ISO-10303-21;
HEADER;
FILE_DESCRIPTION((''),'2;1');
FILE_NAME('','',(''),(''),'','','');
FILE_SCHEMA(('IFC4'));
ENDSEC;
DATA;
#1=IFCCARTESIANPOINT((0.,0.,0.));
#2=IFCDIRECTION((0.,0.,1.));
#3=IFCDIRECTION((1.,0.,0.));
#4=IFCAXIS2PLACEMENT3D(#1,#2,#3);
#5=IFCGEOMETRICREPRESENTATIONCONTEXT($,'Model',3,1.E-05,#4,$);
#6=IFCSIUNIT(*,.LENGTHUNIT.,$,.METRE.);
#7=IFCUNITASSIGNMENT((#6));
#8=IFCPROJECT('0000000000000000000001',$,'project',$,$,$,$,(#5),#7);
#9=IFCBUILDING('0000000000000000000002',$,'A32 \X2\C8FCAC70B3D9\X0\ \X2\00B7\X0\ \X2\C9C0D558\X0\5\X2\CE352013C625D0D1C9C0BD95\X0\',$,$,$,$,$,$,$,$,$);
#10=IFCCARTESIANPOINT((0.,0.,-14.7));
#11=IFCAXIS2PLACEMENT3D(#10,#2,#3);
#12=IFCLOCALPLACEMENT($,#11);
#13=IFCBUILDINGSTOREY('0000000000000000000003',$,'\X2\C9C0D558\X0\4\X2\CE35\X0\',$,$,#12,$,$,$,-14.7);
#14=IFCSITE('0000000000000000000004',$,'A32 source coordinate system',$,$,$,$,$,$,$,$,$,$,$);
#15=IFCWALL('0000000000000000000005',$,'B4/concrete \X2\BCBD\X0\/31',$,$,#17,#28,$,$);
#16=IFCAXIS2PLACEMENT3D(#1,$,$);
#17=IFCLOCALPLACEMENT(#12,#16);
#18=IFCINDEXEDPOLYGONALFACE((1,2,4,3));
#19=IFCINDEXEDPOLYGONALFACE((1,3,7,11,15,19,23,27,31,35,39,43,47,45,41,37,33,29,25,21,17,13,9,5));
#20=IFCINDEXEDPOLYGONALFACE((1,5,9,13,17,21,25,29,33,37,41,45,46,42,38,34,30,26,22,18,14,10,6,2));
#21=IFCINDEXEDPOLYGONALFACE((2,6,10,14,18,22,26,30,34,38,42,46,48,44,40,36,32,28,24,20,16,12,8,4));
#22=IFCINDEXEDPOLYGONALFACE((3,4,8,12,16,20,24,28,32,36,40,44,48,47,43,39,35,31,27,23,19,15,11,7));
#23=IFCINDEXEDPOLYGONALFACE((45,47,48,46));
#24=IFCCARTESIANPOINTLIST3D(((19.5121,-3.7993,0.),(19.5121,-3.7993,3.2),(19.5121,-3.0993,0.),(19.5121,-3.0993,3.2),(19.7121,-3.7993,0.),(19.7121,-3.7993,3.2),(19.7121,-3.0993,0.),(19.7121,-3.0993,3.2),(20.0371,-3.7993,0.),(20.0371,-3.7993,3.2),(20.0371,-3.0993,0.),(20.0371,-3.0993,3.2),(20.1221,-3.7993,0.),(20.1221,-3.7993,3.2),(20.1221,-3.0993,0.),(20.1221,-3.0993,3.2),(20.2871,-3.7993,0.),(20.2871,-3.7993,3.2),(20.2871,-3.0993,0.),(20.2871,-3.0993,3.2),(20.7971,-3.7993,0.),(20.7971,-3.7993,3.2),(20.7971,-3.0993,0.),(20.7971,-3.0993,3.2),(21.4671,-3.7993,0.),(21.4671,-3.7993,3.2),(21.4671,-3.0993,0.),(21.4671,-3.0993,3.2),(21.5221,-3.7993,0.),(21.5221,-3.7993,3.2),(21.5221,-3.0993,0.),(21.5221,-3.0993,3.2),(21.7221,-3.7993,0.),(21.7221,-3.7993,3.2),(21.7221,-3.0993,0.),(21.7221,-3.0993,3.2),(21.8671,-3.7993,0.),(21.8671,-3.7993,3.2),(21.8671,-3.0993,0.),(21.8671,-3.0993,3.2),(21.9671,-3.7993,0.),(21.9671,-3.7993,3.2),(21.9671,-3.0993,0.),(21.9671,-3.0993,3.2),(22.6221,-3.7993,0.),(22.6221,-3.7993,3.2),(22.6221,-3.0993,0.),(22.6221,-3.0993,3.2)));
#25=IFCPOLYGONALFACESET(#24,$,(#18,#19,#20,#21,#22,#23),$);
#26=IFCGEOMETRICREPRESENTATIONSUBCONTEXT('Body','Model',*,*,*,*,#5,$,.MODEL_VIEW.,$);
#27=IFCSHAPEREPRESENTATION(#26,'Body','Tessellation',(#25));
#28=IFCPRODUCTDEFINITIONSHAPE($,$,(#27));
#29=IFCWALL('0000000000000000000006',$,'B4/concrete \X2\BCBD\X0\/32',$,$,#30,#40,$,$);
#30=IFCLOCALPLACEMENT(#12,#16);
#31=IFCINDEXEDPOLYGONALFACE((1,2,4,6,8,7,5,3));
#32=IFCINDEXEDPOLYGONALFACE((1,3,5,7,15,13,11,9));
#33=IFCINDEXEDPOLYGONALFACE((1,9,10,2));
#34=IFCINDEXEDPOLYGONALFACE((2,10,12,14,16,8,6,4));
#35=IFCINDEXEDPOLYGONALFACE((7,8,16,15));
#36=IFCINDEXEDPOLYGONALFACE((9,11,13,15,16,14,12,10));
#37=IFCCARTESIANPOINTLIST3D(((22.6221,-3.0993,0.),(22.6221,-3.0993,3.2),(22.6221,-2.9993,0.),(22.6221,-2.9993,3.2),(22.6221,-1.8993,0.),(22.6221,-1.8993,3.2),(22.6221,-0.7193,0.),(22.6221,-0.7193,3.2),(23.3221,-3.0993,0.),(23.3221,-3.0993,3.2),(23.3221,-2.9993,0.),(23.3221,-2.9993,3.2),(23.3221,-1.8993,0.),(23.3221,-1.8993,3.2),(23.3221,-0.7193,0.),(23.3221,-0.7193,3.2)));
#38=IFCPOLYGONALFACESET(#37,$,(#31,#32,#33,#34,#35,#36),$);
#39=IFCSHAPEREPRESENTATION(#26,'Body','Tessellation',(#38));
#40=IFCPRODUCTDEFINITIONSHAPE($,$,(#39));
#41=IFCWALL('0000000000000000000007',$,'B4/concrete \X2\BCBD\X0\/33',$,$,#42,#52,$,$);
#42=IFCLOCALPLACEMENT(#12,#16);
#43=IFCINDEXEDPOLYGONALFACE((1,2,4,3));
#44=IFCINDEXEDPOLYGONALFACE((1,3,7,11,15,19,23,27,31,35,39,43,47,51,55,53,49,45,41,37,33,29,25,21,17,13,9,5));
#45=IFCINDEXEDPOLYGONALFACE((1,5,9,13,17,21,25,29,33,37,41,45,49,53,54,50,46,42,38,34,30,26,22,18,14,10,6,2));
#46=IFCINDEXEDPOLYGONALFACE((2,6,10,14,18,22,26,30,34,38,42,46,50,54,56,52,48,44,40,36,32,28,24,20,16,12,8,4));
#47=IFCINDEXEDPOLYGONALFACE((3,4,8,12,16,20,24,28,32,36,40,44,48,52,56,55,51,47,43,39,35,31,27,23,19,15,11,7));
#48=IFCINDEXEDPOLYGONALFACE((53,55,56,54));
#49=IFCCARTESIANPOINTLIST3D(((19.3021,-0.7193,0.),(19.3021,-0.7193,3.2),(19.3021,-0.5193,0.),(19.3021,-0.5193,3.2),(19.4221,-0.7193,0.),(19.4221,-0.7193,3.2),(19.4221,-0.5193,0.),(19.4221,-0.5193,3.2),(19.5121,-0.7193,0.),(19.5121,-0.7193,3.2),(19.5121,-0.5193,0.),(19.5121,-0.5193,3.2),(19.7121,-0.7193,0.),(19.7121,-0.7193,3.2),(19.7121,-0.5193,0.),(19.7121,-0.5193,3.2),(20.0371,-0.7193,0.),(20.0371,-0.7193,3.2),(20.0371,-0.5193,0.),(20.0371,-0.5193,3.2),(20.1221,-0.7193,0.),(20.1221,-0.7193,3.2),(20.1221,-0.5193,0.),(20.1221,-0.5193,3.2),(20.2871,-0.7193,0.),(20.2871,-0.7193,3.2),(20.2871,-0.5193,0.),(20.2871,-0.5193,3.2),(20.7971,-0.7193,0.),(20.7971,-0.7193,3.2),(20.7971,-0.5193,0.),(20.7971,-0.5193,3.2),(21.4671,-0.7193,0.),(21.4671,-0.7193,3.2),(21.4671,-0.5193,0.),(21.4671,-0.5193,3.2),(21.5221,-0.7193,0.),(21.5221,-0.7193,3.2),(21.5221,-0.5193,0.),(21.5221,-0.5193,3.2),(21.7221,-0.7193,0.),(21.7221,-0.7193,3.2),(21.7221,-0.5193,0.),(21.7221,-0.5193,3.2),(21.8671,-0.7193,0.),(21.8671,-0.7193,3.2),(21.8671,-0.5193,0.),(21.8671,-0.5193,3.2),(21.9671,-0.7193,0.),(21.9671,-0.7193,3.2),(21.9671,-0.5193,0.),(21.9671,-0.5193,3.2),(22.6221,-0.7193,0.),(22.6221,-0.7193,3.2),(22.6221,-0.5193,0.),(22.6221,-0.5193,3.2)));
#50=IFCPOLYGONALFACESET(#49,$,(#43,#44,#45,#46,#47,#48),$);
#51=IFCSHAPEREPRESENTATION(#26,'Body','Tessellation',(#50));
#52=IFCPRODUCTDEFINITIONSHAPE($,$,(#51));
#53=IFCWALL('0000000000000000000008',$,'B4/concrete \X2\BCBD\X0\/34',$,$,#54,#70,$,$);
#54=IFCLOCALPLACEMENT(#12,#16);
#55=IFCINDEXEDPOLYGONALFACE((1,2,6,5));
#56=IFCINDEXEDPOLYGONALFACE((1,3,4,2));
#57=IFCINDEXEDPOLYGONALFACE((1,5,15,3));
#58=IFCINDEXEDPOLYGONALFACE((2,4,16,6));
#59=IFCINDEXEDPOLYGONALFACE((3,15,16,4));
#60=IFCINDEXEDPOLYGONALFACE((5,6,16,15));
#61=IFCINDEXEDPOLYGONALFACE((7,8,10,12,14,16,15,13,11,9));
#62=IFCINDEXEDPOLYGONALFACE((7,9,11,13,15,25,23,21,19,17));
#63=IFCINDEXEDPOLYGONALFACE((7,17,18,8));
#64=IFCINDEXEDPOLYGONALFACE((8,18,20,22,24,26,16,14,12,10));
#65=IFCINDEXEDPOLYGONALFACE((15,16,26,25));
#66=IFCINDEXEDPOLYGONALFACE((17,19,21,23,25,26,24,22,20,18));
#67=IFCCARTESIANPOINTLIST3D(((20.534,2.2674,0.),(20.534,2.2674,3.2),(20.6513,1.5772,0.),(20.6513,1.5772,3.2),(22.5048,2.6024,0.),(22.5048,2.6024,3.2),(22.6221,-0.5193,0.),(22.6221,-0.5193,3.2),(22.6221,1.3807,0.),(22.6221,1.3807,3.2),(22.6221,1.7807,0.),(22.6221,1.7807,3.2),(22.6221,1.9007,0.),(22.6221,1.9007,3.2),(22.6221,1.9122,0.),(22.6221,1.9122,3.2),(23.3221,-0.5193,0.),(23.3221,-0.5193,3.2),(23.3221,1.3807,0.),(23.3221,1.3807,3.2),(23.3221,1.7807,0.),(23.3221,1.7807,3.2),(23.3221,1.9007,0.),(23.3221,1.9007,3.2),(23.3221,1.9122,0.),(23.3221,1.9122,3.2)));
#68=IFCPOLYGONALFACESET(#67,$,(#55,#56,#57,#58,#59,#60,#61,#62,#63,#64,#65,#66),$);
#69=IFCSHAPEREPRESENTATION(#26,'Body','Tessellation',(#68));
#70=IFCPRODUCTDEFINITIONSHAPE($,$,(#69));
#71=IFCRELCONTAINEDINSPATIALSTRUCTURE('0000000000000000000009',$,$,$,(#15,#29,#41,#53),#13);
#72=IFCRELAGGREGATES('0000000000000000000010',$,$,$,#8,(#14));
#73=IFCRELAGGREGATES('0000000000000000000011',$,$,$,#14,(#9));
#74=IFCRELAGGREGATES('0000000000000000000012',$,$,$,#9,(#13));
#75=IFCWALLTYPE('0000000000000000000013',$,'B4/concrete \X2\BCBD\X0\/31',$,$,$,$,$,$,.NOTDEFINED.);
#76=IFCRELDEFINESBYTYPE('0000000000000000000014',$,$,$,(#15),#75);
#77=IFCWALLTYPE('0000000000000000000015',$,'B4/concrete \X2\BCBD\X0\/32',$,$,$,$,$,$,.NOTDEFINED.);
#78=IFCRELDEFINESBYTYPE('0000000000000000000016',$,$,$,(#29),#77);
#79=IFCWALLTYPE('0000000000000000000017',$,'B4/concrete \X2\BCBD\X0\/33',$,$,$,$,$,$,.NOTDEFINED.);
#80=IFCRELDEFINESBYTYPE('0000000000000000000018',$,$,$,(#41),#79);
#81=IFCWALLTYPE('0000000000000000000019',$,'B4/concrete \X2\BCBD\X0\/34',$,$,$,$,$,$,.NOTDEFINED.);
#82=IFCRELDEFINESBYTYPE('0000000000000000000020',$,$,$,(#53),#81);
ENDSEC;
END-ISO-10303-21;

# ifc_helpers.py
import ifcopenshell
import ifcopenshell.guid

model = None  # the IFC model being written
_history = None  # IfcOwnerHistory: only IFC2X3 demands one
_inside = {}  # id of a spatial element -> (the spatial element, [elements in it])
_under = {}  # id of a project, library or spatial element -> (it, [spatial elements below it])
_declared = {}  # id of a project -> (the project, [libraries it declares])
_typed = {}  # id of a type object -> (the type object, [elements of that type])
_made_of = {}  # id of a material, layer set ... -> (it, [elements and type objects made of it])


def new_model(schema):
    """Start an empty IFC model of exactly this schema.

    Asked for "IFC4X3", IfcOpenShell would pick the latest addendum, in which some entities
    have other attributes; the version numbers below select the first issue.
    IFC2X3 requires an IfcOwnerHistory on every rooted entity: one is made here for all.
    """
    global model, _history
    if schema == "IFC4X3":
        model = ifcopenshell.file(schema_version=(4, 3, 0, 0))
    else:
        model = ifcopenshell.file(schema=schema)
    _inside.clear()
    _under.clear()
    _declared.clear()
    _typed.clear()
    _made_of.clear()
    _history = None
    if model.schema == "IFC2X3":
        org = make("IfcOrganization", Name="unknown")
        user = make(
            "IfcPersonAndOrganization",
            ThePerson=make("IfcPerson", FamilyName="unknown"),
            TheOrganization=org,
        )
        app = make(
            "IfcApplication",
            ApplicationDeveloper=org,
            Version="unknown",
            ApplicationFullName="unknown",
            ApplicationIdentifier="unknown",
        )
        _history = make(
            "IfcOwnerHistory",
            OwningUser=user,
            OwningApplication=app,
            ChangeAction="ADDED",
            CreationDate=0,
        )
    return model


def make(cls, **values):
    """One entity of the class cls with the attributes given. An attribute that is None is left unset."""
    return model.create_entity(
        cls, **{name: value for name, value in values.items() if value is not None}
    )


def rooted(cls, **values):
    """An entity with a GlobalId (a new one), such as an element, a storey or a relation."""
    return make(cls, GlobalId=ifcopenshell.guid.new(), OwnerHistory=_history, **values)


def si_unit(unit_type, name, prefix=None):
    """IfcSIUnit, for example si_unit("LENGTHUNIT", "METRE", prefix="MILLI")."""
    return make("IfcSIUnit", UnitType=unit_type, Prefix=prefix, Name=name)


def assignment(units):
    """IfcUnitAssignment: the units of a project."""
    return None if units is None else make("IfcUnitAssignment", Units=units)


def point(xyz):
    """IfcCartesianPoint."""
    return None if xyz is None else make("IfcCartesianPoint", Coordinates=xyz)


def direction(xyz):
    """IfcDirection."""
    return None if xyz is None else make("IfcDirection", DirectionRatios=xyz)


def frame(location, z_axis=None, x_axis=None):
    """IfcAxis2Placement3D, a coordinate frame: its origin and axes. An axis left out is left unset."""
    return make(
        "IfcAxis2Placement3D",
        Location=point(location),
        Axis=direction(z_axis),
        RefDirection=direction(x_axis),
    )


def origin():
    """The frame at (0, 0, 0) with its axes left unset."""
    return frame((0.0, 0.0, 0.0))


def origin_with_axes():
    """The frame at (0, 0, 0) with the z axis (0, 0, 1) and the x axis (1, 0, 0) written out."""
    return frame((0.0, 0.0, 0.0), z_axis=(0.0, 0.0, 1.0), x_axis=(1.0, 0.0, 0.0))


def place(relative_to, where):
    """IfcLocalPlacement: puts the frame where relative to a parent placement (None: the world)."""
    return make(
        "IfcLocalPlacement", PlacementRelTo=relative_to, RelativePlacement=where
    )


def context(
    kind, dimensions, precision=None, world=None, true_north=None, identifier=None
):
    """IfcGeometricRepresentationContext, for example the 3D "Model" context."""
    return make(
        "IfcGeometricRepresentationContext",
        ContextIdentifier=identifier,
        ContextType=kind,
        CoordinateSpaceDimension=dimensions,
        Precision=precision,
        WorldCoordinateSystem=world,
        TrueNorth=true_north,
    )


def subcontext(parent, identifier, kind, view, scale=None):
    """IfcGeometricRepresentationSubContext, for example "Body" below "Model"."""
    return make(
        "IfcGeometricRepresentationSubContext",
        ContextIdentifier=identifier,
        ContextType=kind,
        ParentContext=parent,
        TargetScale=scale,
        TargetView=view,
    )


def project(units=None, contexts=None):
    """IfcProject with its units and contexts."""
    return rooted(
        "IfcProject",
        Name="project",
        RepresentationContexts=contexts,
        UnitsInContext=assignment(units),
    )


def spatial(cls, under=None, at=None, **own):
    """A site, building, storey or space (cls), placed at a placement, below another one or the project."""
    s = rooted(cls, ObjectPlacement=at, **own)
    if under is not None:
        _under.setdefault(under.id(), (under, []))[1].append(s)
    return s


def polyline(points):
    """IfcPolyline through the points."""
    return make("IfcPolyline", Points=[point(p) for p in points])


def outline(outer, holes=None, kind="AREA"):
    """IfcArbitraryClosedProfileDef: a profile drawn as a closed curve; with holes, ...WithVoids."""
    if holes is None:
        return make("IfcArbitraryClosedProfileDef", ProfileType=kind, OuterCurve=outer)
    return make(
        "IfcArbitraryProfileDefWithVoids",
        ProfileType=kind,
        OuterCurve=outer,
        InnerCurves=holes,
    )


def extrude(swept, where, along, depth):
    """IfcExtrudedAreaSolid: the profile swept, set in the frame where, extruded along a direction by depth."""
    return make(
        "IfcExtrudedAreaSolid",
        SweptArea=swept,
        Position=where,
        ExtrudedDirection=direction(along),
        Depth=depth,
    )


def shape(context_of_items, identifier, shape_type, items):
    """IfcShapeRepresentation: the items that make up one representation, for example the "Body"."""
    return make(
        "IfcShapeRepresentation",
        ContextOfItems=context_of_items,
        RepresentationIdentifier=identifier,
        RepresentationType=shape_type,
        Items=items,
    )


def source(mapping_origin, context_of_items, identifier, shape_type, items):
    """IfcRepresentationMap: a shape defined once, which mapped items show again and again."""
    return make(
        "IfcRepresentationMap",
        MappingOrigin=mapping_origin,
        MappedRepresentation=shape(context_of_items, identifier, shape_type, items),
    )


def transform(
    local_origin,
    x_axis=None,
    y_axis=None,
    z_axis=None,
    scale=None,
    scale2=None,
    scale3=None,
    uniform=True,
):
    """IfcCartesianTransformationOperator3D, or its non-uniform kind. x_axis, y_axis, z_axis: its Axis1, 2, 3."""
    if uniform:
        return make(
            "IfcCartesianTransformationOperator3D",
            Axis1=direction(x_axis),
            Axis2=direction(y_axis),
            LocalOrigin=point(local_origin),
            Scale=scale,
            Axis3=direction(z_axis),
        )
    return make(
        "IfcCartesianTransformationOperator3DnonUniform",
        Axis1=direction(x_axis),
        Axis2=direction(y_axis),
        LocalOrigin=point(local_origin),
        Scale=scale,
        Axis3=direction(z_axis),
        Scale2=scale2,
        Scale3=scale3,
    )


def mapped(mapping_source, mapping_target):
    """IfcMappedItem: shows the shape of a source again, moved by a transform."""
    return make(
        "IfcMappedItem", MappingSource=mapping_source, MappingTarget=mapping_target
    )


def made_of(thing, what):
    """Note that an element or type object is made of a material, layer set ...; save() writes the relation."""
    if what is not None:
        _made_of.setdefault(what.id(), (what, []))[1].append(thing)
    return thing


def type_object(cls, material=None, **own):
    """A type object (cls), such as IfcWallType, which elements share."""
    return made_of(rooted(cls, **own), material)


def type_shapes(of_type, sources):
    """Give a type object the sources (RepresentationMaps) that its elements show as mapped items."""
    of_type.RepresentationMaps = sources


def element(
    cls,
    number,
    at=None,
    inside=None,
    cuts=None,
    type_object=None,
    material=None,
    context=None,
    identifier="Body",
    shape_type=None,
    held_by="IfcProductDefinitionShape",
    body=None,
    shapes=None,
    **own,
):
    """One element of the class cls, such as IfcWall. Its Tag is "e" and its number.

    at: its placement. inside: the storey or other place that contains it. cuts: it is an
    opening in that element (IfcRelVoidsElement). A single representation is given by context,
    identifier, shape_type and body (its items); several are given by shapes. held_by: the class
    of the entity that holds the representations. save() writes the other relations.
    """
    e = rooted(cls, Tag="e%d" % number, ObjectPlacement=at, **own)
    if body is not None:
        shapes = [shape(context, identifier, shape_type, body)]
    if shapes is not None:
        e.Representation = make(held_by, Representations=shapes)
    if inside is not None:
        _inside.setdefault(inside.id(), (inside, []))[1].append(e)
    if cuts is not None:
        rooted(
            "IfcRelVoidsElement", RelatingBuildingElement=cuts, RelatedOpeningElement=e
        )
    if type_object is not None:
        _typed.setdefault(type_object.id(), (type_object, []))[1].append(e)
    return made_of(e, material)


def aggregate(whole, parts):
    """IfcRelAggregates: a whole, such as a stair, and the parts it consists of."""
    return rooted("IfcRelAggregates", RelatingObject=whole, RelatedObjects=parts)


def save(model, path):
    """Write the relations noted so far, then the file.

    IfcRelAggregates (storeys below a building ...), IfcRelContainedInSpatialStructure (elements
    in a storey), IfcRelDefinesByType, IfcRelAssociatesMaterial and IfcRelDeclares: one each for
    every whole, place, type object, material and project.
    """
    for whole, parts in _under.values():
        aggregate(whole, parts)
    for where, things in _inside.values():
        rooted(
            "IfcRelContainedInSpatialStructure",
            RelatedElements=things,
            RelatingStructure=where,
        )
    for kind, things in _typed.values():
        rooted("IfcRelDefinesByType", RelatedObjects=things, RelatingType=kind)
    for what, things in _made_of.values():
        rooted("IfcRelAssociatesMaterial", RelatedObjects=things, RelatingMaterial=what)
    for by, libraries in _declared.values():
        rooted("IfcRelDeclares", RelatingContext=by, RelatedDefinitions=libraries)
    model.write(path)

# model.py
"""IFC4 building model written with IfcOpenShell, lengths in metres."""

from ifc_helpers import new_model, si_unit, frame, origin, origin_with_axes, place, context, subcontext, project, spatial, polyline, outline, extrude, source, transform, mapped, type_object, type_shapes, element, save


model = new_model("IFC4")

# Units and contexts
model_context = context("Model", 3, precision=1e-05, world=origin_with_axes())
body_context = subcontext(model_context, "Body", "Model", "MODEL_VIEW")
ifc_project = project(units=[si_unit("LENGTHUNIT", "METRE")], contexts=[model_context])

# Site, building, storey
site = spatial("IfcSite", under=ifc_project, Name="A32 source coordinate system")
building = spatial("IfcBuilding", under=site, Name="A32 주거동 · 지하5층–옥탑지붕")
storey_placement = place(None, frame((0.0, 0.0, -14.7), z_axis=(0.0, 0.0, 1.0), x_axis=(1.0, 0.0, 0.0)))
storey = spatial("IfcBuildingStorey", under=building, at=storey_placement, Name="지하4층", Elevation=-14.7)

# Walls
wall_type_1 = type_object("IfcWallType", Name="B4/concrete 벽/31", PredefinedType="NOTDEFINED")
shared_shape_1 = source(origin(), body_context, "Body", "SweptSolid", [
    extrude(outline(polyline([(20.1221, -3.0993), (20.2871, -3.0993), (20.7971, -3.0993), (21.4671, -3.0993), (21.5221, -3.0993), (21.7221, -3.0993), (21.8671, -3.0993), (21.9671, -3.0993), (22.6221, -3.0993), (22.6221, -3.7993), (21.9671, -3.7993), (21.8671, -3.7993), (21.7221, -3.7993), (21.5221, -3.7993), (21.4671, -3.7993), (20.7971, -3.7993), (20.2871, -3.7993), (20.1221, -3.7993), (20.0371, -3.7993), (19.7121, -3.7993), (19.5121, -3.7993), (19.5121, -3.0993), (19.7121, -3.0993), (20.0371, -3.0993), (20.1221, -3.0993)])), origin(), (0.0, 0.0, 1.0), 3.2),
])
type_shapes(wall_type_1, [shared_shape_1])
wall_1_placement = place(storey_placement, origin_with_axes())
element("IfcWall", 1, at=wall_1_placement, inside=storey, type_object=wall_type_1, Name="B4/concrete 벽/31", context=body_context, shape_type="MappedRepresentation", body=[
    mapped(shared_shape_1, transform((0.0, 0.0, 0.0), scale=1.0)),
])
wall_type_2 = type_object("IfcWallType", Name="B4/concrete 벽/32", PredefinedType="NOTDEFINED")
shared_shape_2 = source(origin(), body_context, "Body", "SweptSolid", [
    extrude(outline(polyline([(22.6221, -0.7193), (23.3221, -0.7193), (23.3221, -1.8993), (23.3221, -2.9993), (23.3221, -3.0993), (22.6221, -3.0993), (22.6221, -2.9993), (22.6221, -1.8993), (22.6221, -0.7193)])), origin(), (0.0, 0.0, 1.0), 3.2),
])
type_shapes(wall_type_2, [shared_shape_2])
wall_2_placement = place(storey_placement, origin_with_axes())
element("IfcWall", 2, at=wall_2_placement, inside=storey, type_object=wall_type_2, Name="B4/concrete 벽/32", context=body_context, shape_type="MappedRepresentation", body=[
    mapped(shared_shape_2, transform((0.0, 0.0, 0.0), scale=1.0)),
])
wall_type_3 = type_object("IfcWallType", Name="B4/concrete 벽/33", PredefinedType="NOTDEFINED")
shared_shape_3 = source(origin(), body_context, "Body", "SweptSolid", [
    extrude(outline(polyline([(21.7221, -0.7193), (21.5221, -0.7193), (21.4671, -0.7193), (20.7971, -0.7193), (20.2871, -0.7193), (20.1221, -0.7193), (20.0371, -0.7193), (19.7121, -0.7193), (19.5121, -0.7193), (19.4221, -0.7193), (19.3021, -0.7193), (19.3021, -0.5193), (19.4221, -0.5193), (19.5121, -0.5193), (19.7121, -0.5193), (20.0371, -0.5193), (20.1221, -0.5193), (20.2871, -0.5193), (20.7971, -0.5193), (21.4671, -0.5193), (21.5221, -0.5193), (21.7221, -0.5193), (21.8671, -0.5193), (21.9671, -0.5193), (22.6221, -0.5193), (22.6221, -0.7193), (21.9671, -0.7193), (21.8671, -0.7193), (21.7221, -0.7193)])), origin(), (0.0, 0.0, 1.0), 3.2),
])
type_shapes(wall_type_3, [shared_shape_3])
wall_3_placement = place(storey_placement, origin_with_axes())
element("IfcWall", 3, at=wall_3_placement, inside=storey, type_object=wall_type_3, Name="B4/concrete 벽/33", context=body_context, shape_type="MappedRepresentation", body=[
    mapped(shared_shape_3, transform((0.0, 0.0, 0.0), scale=1.0)),
])
wall_type_4 = type_object("IfcWallType", Name="B4/concrete 벽/34", PredefinedType="NOTDEFINED")
shared_shape_4 = source(origin(), body_context, "Body", "SweptSolid", [
    extrude(outline(polyline([(22.6221, 1.9007), (22.6221, 1.9122), (20.6513, 1.5772), (20.534, 2.2674), (22.5048, 2.6024), (22.6221, 1.9122), (23.3221, 1.9122), (23.3221, 1.9007), (23.3221, 1.7807), (23.3221, 1.3807), (23.3221, -0.5193), (22.6221, -0.5193), (22.6221, 1.3807), (22.6221, 1.7807), (22.6221, 1.9007)])), origin(), (0.0, 0.0, 1.0), 3.2),
])
type_shapes(wall_type_4, [shared_shape_4])
wall_4_placement = place(storey_placement, origin_with_axes())
element("IfcWall", 4, at=wall_4_placement, inside=storey, type_object=wall_type_4, Name="B4/concrete 벽/34", context=body_context, shape_type="MappedRepresentation", body=[
    mapped(shared_shape_4, transform((0.0, 0.0, 0.0), scale=1.0)),
])

save(model, "model.ifc")
